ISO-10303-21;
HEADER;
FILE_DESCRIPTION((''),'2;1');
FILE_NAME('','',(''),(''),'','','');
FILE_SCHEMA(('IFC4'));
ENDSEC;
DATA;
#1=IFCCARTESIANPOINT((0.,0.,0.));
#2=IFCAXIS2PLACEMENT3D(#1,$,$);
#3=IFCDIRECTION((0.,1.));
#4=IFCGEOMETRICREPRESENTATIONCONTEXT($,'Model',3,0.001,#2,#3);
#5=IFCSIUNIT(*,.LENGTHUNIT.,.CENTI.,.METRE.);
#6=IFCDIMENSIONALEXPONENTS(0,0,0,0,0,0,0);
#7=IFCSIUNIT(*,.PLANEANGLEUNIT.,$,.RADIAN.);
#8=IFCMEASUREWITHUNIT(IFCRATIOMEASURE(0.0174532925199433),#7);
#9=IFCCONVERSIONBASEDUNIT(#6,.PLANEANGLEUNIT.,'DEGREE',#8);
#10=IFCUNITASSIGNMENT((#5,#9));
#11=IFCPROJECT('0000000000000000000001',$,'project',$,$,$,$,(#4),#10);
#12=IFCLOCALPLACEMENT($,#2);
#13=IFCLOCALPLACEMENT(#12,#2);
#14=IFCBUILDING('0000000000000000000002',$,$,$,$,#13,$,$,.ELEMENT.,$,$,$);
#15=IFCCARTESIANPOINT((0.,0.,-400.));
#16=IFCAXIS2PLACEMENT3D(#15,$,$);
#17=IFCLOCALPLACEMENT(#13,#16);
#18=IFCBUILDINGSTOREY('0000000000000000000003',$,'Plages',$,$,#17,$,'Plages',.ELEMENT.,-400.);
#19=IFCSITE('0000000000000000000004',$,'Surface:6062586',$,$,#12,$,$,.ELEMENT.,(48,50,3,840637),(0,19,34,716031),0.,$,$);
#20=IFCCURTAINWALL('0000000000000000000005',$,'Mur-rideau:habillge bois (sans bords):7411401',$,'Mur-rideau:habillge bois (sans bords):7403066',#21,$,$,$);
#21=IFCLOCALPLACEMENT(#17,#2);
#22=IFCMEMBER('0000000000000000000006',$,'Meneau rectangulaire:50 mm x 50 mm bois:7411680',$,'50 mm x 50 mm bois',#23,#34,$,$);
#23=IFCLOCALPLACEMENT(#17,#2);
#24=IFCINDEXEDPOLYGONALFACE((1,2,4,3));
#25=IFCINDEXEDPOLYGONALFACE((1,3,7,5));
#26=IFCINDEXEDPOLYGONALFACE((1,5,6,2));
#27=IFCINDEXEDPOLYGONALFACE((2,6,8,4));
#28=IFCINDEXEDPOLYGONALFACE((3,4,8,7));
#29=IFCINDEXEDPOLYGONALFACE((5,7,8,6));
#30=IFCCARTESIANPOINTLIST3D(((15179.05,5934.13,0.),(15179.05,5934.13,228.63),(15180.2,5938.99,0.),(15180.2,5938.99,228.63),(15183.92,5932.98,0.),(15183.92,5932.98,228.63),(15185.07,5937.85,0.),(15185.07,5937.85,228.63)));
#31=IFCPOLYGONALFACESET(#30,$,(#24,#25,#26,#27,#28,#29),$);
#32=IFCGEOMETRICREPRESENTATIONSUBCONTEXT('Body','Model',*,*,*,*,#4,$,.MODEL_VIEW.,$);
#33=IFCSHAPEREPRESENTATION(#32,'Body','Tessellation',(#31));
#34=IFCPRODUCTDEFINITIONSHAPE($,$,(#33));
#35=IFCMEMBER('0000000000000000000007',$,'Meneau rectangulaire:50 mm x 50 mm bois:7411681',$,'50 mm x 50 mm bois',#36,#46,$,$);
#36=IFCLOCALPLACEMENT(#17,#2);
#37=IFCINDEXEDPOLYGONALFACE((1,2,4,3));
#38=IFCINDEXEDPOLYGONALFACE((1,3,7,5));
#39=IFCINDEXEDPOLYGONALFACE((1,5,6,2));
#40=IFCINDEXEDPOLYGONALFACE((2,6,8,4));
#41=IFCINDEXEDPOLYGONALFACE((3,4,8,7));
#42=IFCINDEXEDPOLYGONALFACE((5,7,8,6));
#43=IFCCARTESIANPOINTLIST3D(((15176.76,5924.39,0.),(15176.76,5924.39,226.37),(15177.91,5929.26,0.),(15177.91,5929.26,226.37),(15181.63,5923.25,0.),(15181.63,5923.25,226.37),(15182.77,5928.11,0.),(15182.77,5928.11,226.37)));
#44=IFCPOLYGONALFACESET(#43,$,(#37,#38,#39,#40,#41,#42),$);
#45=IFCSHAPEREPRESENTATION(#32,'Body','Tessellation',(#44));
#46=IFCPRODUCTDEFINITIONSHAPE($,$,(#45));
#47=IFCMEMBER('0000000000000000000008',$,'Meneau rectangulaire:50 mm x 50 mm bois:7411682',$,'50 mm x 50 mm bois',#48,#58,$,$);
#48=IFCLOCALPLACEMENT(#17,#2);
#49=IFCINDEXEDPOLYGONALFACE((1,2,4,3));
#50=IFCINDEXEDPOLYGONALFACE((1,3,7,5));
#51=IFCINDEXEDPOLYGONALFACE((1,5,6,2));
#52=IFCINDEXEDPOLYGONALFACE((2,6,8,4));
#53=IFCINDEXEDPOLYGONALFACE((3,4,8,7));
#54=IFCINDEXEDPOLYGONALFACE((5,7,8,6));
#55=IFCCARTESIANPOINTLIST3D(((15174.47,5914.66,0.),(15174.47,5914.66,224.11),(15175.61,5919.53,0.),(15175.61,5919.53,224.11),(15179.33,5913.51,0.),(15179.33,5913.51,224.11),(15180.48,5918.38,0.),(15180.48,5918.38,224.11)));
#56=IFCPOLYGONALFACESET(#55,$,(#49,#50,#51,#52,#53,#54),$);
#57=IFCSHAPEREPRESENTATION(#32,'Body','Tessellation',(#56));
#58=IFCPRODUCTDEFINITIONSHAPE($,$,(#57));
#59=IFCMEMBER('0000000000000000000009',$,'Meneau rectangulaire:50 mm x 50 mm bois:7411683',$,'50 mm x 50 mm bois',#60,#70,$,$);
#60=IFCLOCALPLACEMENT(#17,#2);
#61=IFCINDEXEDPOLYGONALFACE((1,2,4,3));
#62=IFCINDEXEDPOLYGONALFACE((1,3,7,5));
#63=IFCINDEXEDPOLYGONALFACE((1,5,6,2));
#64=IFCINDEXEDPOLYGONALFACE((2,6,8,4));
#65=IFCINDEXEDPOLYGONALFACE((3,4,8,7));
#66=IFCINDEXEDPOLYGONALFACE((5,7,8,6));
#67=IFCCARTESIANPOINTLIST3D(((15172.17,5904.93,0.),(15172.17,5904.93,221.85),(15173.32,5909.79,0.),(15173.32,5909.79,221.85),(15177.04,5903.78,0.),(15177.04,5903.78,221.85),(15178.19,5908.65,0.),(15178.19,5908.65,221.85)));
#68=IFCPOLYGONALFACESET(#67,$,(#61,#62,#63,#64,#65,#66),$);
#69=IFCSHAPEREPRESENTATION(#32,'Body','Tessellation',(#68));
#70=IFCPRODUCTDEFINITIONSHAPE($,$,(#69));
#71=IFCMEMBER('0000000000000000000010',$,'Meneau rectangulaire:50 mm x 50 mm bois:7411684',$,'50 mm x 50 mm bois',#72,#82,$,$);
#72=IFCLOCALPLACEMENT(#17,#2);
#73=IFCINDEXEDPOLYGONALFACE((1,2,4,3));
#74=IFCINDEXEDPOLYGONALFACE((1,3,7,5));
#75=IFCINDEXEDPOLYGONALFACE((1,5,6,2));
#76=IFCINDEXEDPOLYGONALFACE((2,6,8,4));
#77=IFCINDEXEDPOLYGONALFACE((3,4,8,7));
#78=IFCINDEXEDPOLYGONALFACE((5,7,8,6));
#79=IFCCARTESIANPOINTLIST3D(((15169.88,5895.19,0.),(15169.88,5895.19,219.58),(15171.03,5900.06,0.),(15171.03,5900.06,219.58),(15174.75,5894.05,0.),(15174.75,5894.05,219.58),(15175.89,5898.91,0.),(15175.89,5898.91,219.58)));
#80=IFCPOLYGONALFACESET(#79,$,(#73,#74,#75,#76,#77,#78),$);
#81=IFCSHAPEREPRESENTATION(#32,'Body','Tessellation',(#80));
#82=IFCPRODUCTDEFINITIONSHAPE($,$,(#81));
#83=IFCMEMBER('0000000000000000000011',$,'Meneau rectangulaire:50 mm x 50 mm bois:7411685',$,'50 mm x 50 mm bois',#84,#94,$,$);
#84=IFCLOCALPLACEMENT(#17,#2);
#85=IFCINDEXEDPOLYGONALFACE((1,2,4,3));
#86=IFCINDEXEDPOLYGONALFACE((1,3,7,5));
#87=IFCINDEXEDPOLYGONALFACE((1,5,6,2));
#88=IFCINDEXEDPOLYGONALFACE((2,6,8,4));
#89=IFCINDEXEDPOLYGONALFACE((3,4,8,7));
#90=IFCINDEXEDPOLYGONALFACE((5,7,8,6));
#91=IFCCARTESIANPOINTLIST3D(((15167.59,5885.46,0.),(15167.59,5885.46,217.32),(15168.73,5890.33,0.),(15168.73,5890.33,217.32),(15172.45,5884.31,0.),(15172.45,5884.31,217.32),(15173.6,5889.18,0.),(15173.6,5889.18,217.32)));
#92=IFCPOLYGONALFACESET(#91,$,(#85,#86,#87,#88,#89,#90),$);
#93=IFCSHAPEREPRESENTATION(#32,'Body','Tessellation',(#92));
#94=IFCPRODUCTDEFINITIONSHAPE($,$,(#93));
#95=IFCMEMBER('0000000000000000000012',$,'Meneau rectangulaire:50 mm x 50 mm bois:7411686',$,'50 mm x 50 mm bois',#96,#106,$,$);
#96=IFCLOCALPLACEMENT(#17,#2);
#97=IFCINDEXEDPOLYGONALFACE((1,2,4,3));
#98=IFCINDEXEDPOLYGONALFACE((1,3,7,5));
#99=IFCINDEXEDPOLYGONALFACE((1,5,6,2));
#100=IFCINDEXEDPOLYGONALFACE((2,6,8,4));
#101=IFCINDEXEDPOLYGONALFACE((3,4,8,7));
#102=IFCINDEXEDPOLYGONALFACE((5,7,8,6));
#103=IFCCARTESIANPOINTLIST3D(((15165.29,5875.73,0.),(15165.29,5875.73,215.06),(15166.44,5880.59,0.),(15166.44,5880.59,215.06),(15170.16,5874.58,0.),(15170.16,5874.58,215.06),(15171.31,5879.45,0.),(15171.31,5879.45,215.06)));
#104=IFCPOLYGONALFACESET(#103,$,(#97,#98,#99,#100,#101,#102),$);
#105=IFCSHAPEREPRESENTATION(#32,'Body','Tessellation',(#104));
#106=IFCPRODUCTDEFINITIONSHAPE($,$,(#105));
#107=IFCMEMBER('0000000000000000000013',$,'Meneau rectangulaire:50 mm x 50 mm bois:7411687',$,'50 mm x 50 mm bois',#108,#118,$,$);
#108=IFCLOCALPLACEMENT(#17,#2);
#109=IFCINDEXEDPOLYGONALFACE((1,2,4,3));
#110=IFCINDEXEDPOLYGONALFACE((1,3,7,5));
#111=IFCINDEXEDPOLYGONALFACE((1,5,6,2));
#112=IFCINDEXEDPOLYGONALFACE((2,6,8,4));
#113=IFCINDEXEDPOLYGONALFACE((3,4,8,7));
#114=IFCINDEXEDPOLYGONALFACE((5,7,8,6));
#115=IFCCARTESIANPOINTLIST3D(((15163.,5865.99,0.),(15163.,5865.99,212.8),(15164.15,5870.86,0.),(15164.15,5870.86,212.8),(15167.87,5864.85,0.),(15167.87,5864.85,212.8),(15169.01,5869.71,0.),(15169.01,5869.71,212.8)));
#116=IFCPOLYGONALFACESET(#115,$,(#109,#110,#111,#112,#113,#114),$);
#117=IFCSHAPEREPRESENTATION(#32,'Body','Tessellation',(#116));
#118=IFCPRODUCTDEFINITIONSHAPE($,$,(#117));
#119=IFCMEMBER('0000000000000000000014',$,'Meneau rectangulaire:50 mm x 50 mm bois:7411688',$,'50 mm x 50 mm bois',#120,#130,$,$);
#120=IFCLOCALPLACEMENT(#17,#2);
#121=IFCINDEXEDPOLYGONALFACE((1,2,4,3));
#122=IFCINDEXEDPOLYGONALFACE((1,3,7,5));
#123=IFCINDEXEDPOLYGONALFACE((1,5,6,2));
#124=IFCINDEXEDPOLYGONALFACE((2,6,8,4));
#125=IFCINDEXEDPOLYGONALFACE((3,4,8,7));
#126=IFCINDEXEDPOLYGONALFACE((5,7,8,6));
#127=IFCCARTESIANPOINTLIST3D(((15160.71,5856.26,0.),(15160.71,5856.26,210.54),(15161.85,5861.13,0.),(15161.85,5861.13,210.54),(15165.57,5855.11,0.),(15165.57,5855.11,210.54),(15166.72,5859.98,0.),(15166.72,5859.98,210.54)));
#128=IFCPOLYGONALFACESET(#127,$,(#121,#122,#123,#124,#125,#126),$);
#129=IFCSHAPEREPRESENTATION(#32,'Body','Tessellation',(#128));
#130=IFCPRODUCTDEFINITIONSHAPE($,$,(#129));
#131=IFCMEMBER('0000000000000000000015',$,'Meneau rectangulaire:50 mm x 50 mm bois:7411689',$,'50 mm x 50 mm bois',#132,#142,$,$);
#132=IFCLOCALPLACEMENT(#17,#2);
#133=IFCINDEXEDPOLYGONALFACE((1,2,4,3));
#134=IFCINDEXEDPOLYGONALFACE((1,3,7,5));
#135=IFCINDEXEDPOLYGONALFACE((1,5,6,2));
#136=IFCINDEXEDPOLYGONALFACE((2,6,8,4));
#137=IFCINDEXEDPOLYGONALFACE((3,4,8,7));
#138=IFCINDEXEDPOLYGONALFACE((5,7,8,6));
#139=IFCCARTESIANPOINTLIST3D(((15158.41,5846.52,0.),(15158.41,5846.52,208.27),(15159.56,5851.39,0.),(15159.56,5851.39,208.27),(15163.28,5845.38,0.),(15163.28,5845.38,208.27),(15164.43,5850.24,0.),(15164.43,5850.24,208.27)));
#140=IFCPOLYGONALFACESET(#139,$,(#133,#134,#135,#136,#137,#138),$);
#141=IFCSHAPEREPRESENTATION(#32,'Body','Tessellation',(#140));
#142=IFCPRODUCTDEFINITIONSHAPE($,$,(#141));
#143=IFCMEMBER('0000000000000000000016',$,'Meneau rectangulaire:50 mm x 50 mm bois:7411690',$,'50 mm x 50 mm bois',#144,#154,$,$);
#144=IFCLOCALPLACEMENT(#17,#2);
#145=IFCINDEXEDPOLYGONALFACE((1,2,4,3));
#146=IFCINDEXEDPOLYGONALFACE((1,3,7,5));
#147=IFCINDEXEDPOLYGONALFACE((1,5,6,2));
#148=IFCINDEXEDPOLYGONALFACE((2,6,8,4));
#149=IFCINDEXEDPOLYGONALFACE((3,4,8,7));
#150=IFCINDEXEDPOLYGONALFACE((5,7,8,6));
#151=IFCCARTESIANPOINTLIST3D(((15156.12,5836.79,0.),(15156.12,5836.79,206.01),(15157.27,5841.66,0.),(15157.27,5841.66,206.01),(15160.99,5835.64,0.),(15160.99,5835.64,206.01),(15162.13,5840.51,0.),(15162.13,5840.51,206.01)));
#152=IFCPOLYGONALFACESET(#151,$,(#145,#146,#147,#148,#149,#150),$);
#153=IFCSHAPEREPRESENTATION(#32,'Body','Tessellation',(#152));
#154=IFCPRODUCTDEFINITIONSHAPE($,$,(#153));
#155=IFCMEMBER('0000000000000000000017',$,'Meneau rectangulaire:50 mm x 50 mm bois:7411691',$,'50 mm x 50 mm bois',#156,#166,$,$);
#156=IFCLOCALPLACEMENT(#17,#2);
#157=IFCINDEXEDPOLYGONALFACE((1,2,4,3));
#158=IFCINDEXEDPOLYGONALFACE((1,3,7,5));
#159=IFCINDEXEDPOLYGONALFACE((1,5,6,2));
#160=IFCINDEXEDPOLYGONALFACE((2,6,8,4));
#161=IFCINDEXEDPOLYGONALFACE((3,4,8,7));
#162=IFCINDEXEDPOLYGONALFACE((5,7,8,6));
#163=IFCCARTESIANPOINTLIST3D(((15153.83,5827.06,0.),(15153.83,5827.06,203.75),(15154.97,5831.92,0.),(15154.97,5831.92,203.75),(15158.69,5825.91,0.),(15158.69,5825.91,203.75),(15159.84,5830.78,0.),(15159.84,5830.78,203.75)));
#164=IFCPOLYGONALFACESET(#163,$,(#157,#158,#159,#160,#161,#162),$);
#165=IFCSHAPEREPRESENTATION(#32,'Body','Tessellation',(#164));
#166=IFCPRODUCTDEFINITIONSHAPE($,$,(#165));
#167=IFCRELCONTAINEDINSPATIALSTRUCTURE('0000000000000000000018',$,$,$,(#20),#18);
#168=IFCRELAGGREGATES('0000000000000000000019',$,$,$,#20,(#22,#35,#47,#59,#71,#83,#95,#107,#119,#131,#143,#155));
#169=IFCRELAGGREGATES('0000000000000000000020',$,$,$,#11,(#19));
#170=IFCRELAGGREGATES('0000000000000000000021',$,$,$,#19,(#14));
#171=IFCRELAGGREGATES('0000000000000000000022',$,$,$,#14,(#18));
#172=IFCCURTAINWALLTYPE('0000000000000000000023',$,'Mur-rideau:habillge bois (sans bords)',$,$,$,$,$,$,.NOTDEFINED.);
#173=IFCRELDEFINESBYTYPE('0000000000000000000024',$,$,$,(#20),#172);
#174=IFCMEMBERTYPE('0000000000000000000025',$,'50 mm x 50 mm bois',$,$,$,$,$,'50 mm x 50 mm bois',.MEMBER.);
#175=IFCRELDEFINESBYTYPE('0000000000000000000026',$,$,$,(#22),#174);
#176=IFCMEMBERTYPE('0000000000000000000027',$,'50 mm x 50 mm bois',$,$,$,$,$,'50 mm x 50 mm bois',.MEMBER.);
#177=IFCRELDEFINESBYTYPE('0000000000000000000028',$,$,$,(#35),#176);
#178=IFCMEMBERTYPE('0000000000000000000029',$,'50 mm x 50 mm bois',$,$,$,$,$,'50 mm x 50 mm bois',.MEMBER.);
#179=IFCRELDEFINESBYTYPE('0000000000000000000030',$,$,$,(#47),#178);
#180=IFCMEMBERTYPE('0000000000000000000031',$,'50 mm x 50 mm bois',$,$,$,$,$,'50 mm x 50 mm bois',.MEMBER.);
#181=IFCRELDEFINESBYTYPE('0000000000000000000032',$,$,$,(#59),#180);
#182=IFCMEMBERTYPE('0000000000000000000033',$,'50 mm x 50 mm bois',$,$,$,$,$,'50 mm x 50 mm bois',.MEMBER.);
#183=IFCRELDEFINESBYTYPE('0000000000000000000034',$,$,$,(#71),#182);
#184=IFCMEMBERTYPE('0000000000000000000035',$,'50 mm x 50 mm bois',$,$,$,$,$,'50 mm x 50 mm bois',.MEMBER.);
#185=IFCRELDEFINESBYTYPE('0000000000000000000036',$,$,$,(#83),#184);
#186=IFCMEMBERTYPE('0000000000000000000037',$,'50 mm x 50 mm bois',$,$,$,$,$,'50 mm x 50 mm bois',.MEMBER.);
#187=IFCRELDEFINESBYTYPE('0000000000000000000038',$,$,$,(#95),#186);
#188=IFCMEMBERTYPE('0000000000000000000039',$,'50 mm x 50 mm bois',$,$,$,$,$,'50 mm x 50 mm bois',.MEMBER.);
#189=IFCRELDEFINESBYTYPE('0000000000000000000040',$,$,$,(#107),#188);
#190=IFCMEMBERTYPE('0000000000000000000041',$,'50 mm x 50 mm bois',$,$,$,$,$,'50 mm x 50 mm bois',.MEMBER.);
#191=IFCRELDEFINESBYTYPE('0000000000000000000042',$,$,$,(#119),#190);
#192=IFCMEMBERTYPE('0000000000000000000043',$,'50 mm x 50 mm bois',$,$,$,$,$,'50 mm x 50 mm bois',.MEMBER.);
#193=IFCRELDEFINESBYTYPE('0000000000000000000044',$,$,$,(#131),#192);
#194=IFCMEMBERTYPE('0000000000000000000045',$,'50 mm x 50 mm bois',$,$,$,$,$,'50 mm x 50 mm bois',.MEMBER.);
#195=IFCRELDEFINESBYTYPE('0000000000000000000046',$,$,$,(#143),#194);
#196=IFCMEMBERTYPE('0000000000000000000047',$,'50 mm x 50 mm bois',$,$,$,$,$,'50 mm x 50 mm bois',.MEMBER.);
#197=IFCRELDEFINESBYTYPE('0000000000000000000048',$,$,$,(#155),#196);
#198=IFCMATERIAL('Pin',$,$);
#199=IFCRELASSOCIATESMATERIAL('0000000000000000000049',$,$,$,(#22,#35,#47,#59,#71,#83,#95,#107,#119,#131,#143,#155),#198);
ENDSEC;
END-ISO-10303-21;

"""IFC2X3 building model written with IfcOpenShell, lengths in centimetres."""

from ifc_helpers import new_model, entity, si_unit, converted_unit, direction, frame, origin, origin_2d_with_axis, place, context, subcontext, project, spatial, rectangle, extrude, source, transform, mapped, material, type_object, type_shapes, element, aggregate, save


model = new_model("IFC2X3")

# Units and contexts
model_context = context("Model", 3, precision=0.001, world=origin(), true_north=direction((0.0, 1.0)))
body_context = subcontext(model_context, "Body", "Model", "MODEL_VIEW")
ifc_project = project(units=[si_unit("LENGTHUNIT", "METRE", prefix="CENTI"), converted_unit("PLANEANGLEUNIT", "DEGREE", entity("IfcRatioMeasure", 0.0174532925199433), si_unit("PLANEANGLEUNIT", "RADIAN"), dimensions=[0, 0, 0, 0, 0, 0, 0])], contexts=[model_context])

# Site, building, storey
site_placement = place(None, origin())
site = spatial("IfcSite", under=ifc_project, at=site_placement, Name="Surface:6062586", CompositionType="ELEMENT", RefLatitude=(48, 50, 3, 840637), RefLongitude=(0, 19, 34, 716031), RefElevation=0.0)
building_placement = place(site_placement, origin())
building = spatial("IfcBuilding", under=site, at=building_placement, CompositionType="ELEMENT")
storey_placement = place(building_placement, frame((0.0, 0.0, -400.0)))
storey = spatial("IfcBuildingStorey", under=building, at=storey_placement, Name="Plages", LongName="Plages", CompositionType="ELEMENT", Elevation=-400.0)

# Curtain wall, members
curtain_wall_type = type_object("IfcCurtainWallType", Name="Mur-rideau:habillge bois (sans bords)", PredefinedType="NOTDEFINED")
curtain_wall_placement = place(storey_placement, frame((0.0, 0.0, 400.0)))
curtain_wall = element("IfcCurtainWall", 1, at=curtain_wall_placement, inside=storey, type_object=curtain_wall_type, Name="Mur-rideau:habillge bois (sans bords):7411401", ObjectType="Mur-rideau:habillge bois (sans bords):7403066")
ifc_material_1 = material(Name="Pin")
member_type_1 = type_object("IfcMemberType", Name="50 mm x 50 mm bois", ElementType="50 mm x 50 mm bois", PredefinedType="MEMBER")
shared_shape_1 = source(origin(), body_context, "Body", "SweptSolid", [
    extrude(rectangle(XDim=5.0, YDim=5.0, at=origin_2d_with_axis()), frame((0.0, 0.0, -228.63), z_axis=(0.0, 0.0, 1.0), x_axis=(0.0, -1.0, 0.0)), (0.0, 0.0, 1.0), 228.63),
])
type_shapes(member_type_1, [shared_shape_1])
member_1_placement = place(storey_placement, frame((15182.06, 5935.99, 0.0), z_axis=(0.0, 0.0, -1.0), x_axis=(-0.229349, -0.973344, 0.0)))
member_1 = element("IfcMember", 2, at=member_1_placement, type_object=member_type_1, material=ifc_material_1, Name="Meneau rectangulaire:50 mm x 50 mm bois:7411680", ObjectType="50 mm x 50 mm bois", context=body_context, shape_type="MappedRepresentation", body=[
    mapped(shared_shape_1, transform((0.0, 0.0, 0.0), scale=1.0)),
])
member_type_2 = type_object("IfcMemberType", Name="50 mm x 50 mm bois", ElementType="50 mm x 50 mm bois", PredefinedType="MEMBER")
shared_shape_2 = source(origin(), body_context, "Body", "SweptSolid", [
    extrude(rectangle(XDim=5.0, YDim=5.0, at=origin_2d_with_axis()), frame((0.0, 0.0, -226.37), z_axis=(0.0, 0.0, 1.0), x_axis=(0.0, -1.0, 0.0)), (0.0, 0.0, 1.0), 226.37),
])
type_shapes(member_type_2, [shared_shape_2])
member_2_placement = place(storey_placement, frame((15179.77, 5926.25, 0.0), z_axis=(0.0, 0.0, -1.0), x_axis=(-0.229349, -0.973344, 0.0)))
member_2 = element("IfcMember", 3, at=member_2_placement, type_object=member_type_2, material=ifc_material_1, Name="Meneau rectangulaire:50 mm x 50 mm bois:7411681", ObjectType="50 mm x 50 mm bois", context=body_context, shape_type="MappedRepresentation", body=[
    mapped(shared_shape_2, transform((0.0, 0.0, 0.0), scale=1.0)),
])
member_type_3 = type_object("IfcMemberType", Name="50 mm x 50 mm bois", ElementType="50 mm x 50 mm bois", PredefinedType="MEMBER")
shared_shape_3 = source(origin(), body_context, "Body", "SweptSolid", [
    extrude(rectangle(XDim=5.0, YDim=5.0, at=origin_2d_with_axis()), frame((0.0, 0.0, -224.11), z_axis=(0.0, 0.0, 1.0), x_axis=(0.0, -1.0, 0.0)), (0.0, 0.0, 1.0), 224.11),
])
type_shapes(member_type_3, [shared_shape_3])
member_3_placement = place(storey_placement, frame((15177.47, 5916.52, 0.0), z_axis=(0.0, 0.0, -1.0), x_axis=(-0.229349, -0.973344, 0.0)))
member_3 = element("IfcMember", 4, at=member_3_placement, type_object=member_type_3, material=ifc_material_1, Name="Meneau rectangulaire:50 mm x 50 mm bois:7411682", ObjectType="50 mm x 50 mm bois", context=body_context, shape_type="MappedRepresentation", body=[
    mapped(shared_shape_3, transform((0.0, 0.0, 0.0), scale=1.0)),
])
member_type_4 = type_object("IfcMemberType", Name="50 mm x 50 mm bois", ElementType="50 mm x 50 mm bois", PredefinedType="MEMBER")
shared_shape_4 = source(origin(), body_context, "Body", "SweptSolid", [
    extrude(rectangle(XDim=5.0, YDim=5.0, at=origin_2d_with_axis()), frame((0.0, 0.0, -221.85), z_axis=(0.0, 0.0, 1.0), x_axis=(0.0, -1.0, 0.0)), (0.0, 0.0, 1.0), 221.85),
])
type_shapes(member_type_4, [shared_shape_4])
member_4_placement = place(storey_placement, frame((15175.18, 5906.79, 0.0), z_axis=(0.0, 0.0, -1.0), x_axis=(-0.229349, -0.973344, 0.0)))
member_4 = element("IfcMember", 5, at=member_4_placement, type_object=member_type_4, material=ifc_material_1, Name="Meneau rectangulaire:50 mm x 50 mm bois:7411683", ObjectType="50 mm x 50 mm bois", context=body_context, shape_type="MappedRepresentation", body=[
    mapped(shared_shape_4, transform((0.0, 0.0, 0.0), scale=1.0)),
])
member_type_5 = type_object("IfcMemberType", Name="50 mm x 50 mm bois", ElementType="50 mm x 50 mm bois", PredefinedType="MEMBER")
shared_shape_5 = source(origin(), body_context, "Body", "SweptSolid", [
    extrude(rectangle(XDim=5.0, YDim=5.0, at=origin_2d_with_axis()), frame((0.0, 0.0, -219.58), z_axis=(0.0, 0.0, 1.0), x_axis=(0.0, -1.0, 0.0)), (0.0, 0.0, 1.0), 219.58),
])
type_shapes(member_type_5, [shared_shape_5])
member_5_placement = place(storey_placement, frame((15172.89, 5897.05, 0.0), z_axis=(0.0, 0.0, -1.0), x_axis=(-0.229349, -0.973344, 0.0)))
member_5 = element("IfcMember", 6, at=member_5_placement, type_object=member_type_5, material=ifc_material_1, Name="Meneau rectangulaire:50 mm x 50 mm bois:7411684", ObjectType="50 mm x 50 mm bois", context=body_context, shape_type="MappedRepresentation", body=[
    mapped(shared_shape_5, transform((0.0, 0.0, 0.0), scale=1.0)),
])
member_type_6 = type_object("IfcMemberType", Name="50 mm x 50 mm bois", ElementType="50 mm x 50 mm bois", PredefinedType="MEMBER")
shared_shape_6 = source(origin(), body_context, "Body", "SweptSolid", [
    extrude(rectangle(XDim=5.0, YDim=5.0, at=origin_2d_with_axis()), frame((0.0, 0.0, -217.32), z_axis=(0.0, 0.0, 1.0), x_axis=(0.0, -1.0, 0.0)), (0.0, 0.0, 1.0), 217.32),
])
type_shapes(member_type_6, [shared_shape_6])
member_6_placement = place(storey_placement, frame((15170.59, 5887.32, 0.0), z_axis=(0.0, 0.0, -1.0), x_axis=(-0.229349, -0.973344, 0.0)))
member_6 = element("IfcMember", 7, at=member_6_placement, type_object=member_type_6, material=ifc_material_1, Name="Meneau rectangulaire:50 mm x 50 mm bois:7411685", ObjectType="50 mm x 50 mm bois", context=body_context, shape_type="MappedRepresentation", body=[
    mapped(shared_shape_6, transform((0.0, 0.0, 0.0), scale=1.0)),
])
member_type_7 = type_object("IfcMemberType", Name="50 mm x 50 mm bois", ElementType="50 mm x 50 mm bois", PredefinedType="MEMBER")
shared_shape_7 = source(origin(), body_context, "Body", "SweptSolid", [
    extrude(rectangle(XDim=5.0, YDim=5.0, at=origin_2d_with_axis()), frame((0.0, 0.0, -215.06), z_axis=(0.0, 0.0, 1.0), x_axis=(0.0, -1.0, 0.0)), (0.0, 0.0, 1.0), 215.06),
])
type_shapes(member_type_7, [shared_shape_7])
member_7_placement = place(storey_placement, frame((15168.3, 5877.59, 0.0), z_axis=(0.0, 0.0, -1.0), x_axis=(-0.229349, -0.973344, 0.0)))
member_7 = element("IfcMember", 8, at=member_7_placement, type_object=member_type_7, material=ifc_material_1, Name="Meneau rectangulaire:50 mm x 50 mm bois:7411686", ObjectType="50 mm x 50 mm bois", context=body_context, shape_type="MappedRepresentation", body=[
    mapped(shared_shape_7, transform((0.0, 0.0, 0.0), scale=1.0)),
])
member_type_8 = type_object("IfcMemberType", Name="50 mm x 50 mm bois", ElementType="50 mm x 50 mm bois", PredefinedType="MEMBER")
shared_shape_8 = source(origin(), body_context, "Body", "SweptSolid", [
    extrude(rectangle(XDim=5.0, YDim=5.0, at=origin_2d_with_axis()), frame((0.0, 0.0, -212.8), z_axis=(0.0, 0.0, 1.0), x_axis=(0.0, -1.0, 0.0)), (0.0, 0.0, 1.0), 212.8),
])
type_shapes(member_type_8, [shared_shape_8])
member_8_placement = place(storey_placement, frame((15166.01, 5867.85, 0.0), z_axis=(0.0, 0.0, -1.0), x_axis=(-0.229349, -0.973344, 0.0)))
member_8 = element("IfcMember", 9, at=member_8_placement, type_object=member_type_8, material=ifc_material_1, Name="Meneau rectangulaire:50 mm x 50 mm bois:7411687", ObjectType="50 mm x 50 mm bois", context=body_context, shape_type="MappedRepresentation", body=[
    mapped(shared_shape_8, transform((0.0, 0.0, 0.0), scale=1.0)),
])
member_type_9 = type_object("IfcMemberType", Name="50 mm x 50 mm bois", ElementType="50 mm x 50 mm bois", PredefinedType="MEMBER")
shared_shape_9 = source(origin(), body_context, "Body", "SweptSolid", [
    extrude(rectangle(XDim=5.0, YDim=5.0, at=origin_2d_with_axis()), frame((0.0, 0.0, -210.54), z_axis=(0.0, 0.0, 1.0), x_axis=(0.0, -1.0, 0.0)), (0.0, 0.0, 1.0), 210.54),
])
type_shapes(member_type_9, [shared_shape_9])
member_9_placement = place(storey_placement, frame((15163.71, 5858.12, 0.0), z_axis=(0.0, 0.0, -1.0), x_axis=(-0.229349, -0.973344, 0.0)))
member_9 = element("IfcMember", 10, at=member_9_placement, type_object=member_type_9, material=ifc_material_1, Name="Meneau rectangulaire:50 mm x 50 mm bois:7411688", ObjectType="50 mm x 50 mm bois", context=body_context, shape_type="MappedRepresentation", body=[
    mapped(shared_shape_9, transform((0.0, 0.0, 0.0), scale=1.0)),
])
member_type_10 = type_object("IfcMemberType", Name="50 mm x 50 mm bois", ElementType="50 mm x 50 mm bois", PredefinedType="MEMBER")
shared_shape_10 = source(origin(), body_context, "Body", "SweptSolid", [
    extrude(rectangle(XDim=5.0, YDim=5.0, at=origin_2d_with_axis()), frame((0.0, 0.0, -208.27), z_axis=(0.0, 0.0, 1.0), x_axis=(0.0, -1.0, 0.0)), (0.0, 0.0, 1.0), 208.27),
])
type_shapes(member_type_10, [shared_shape_10])
member_10_placement = place(storey_placement, frame((15161.42, 5848.38, 0.0), z_axis=(0.0, 0.0, -1.0), x_axis=(-0.229349, -0.973344, 0.0)))
member_10 = element("IfcMember", 11, at=member_10_placement, type_object=member_type_10, material=ifc_material_1, Name="Meneau rectangulaire:50 mm x 50 mm bois:7411689", ObjectType="50 mm x 50 mm bois", context=body_context, shape_type="MappedRepresentation", body=[
    mapped(shared_shape_10, transform((0.0, 0.0, 0.0), scale=1.0)),
])
member_type_11 = type_object("IfcMemberType", Name="50 mm x 50 mm bois", ElementType="50 mm x 50 mm bois", PredefinedType="MEMBER")
shared_shape_11 = source(origin(), body_context, "Body", "SweptSolid", [
    extrude(rectangle(XDim=5.0, YDim=5.0, at=origin_2d_with_axis()), frame((0.0, 0.0, -206.01), z_axis=(0.0, 0.0, 1.0), x_axis=(0.0, -1.0, 0.0)), (0.0, 0.0, 1.0), 206.01),
])
type_shapes(member_type_11, [shared_shape_11])
member_11_placement = place(storey_placement, frame((15159.13, 5838.65, 0.0), z_axis=(0.0, 0.0, -1.0), x_axis=(-0.229349, -0.973344, 0.0)))
member_11 = element("IfcMember", 12, at=member_11_placement, type_object=member_type_11, material=ifc_material_1, Name="Meneau rectangulaire:50 mm x 50 mm bois:7411690", ObjectType="50 mm x 50 mm bois", context=body_context, shape_type="MappedRepresentation", body=[
    mapped(shared_shape_11, transform((0.0, 0.0, 0.0), scale=1.0)),
])
member_type_12 = type_object("IfcMemberType", Name="50 mm x 50 mm bois", ElementType="50 mm x 50 mm bois", PredefinedType="MEMBER")
shared_shape_12 = source(origin(), body_context, "Body", "SweptSolid", [
    extrude(rectangle(XDim=5.0, YDim=5.0, at=origin_2d_with_axis()), frame((0.0, 0.0, -203.75), z_axis=(0.0, 0.0, 1.0), x_axis=(0.0, -1.0, 0.0)), (0.0, 0.0, 1.0), 203.75),
])
type_shapes(member_type_12, [shared_shape_12])
member_12_placement = place(storey_placement, frame((15156.83, 5828.92, 0.0), z_axis=(0.0, 0.0, -1.0), x_axis=(-0.229349, -0.973344, 0.0)))
member_12 = element("IfcMember", 13, at=member_12_placement, type_object=member_type_12, material=ifc_material_1, Name="Meneau rectangulaire:50 mm x 50 mm bois:7411691", ObjectType="50 mm x 50 mm bois", context=body_context, shape_type="MappedRepresentation", body=[
    mapped(shared_shape_12, transform((0.0, 0.0, 0.0), scale=1.0)),
])
aggregate(curtain_wall, [member_1, member_2, member_3, member_4, member_5, member_6, member_7, member_8, member_9, member_10, member_11, member_12])

save(model, "model.ifc")
